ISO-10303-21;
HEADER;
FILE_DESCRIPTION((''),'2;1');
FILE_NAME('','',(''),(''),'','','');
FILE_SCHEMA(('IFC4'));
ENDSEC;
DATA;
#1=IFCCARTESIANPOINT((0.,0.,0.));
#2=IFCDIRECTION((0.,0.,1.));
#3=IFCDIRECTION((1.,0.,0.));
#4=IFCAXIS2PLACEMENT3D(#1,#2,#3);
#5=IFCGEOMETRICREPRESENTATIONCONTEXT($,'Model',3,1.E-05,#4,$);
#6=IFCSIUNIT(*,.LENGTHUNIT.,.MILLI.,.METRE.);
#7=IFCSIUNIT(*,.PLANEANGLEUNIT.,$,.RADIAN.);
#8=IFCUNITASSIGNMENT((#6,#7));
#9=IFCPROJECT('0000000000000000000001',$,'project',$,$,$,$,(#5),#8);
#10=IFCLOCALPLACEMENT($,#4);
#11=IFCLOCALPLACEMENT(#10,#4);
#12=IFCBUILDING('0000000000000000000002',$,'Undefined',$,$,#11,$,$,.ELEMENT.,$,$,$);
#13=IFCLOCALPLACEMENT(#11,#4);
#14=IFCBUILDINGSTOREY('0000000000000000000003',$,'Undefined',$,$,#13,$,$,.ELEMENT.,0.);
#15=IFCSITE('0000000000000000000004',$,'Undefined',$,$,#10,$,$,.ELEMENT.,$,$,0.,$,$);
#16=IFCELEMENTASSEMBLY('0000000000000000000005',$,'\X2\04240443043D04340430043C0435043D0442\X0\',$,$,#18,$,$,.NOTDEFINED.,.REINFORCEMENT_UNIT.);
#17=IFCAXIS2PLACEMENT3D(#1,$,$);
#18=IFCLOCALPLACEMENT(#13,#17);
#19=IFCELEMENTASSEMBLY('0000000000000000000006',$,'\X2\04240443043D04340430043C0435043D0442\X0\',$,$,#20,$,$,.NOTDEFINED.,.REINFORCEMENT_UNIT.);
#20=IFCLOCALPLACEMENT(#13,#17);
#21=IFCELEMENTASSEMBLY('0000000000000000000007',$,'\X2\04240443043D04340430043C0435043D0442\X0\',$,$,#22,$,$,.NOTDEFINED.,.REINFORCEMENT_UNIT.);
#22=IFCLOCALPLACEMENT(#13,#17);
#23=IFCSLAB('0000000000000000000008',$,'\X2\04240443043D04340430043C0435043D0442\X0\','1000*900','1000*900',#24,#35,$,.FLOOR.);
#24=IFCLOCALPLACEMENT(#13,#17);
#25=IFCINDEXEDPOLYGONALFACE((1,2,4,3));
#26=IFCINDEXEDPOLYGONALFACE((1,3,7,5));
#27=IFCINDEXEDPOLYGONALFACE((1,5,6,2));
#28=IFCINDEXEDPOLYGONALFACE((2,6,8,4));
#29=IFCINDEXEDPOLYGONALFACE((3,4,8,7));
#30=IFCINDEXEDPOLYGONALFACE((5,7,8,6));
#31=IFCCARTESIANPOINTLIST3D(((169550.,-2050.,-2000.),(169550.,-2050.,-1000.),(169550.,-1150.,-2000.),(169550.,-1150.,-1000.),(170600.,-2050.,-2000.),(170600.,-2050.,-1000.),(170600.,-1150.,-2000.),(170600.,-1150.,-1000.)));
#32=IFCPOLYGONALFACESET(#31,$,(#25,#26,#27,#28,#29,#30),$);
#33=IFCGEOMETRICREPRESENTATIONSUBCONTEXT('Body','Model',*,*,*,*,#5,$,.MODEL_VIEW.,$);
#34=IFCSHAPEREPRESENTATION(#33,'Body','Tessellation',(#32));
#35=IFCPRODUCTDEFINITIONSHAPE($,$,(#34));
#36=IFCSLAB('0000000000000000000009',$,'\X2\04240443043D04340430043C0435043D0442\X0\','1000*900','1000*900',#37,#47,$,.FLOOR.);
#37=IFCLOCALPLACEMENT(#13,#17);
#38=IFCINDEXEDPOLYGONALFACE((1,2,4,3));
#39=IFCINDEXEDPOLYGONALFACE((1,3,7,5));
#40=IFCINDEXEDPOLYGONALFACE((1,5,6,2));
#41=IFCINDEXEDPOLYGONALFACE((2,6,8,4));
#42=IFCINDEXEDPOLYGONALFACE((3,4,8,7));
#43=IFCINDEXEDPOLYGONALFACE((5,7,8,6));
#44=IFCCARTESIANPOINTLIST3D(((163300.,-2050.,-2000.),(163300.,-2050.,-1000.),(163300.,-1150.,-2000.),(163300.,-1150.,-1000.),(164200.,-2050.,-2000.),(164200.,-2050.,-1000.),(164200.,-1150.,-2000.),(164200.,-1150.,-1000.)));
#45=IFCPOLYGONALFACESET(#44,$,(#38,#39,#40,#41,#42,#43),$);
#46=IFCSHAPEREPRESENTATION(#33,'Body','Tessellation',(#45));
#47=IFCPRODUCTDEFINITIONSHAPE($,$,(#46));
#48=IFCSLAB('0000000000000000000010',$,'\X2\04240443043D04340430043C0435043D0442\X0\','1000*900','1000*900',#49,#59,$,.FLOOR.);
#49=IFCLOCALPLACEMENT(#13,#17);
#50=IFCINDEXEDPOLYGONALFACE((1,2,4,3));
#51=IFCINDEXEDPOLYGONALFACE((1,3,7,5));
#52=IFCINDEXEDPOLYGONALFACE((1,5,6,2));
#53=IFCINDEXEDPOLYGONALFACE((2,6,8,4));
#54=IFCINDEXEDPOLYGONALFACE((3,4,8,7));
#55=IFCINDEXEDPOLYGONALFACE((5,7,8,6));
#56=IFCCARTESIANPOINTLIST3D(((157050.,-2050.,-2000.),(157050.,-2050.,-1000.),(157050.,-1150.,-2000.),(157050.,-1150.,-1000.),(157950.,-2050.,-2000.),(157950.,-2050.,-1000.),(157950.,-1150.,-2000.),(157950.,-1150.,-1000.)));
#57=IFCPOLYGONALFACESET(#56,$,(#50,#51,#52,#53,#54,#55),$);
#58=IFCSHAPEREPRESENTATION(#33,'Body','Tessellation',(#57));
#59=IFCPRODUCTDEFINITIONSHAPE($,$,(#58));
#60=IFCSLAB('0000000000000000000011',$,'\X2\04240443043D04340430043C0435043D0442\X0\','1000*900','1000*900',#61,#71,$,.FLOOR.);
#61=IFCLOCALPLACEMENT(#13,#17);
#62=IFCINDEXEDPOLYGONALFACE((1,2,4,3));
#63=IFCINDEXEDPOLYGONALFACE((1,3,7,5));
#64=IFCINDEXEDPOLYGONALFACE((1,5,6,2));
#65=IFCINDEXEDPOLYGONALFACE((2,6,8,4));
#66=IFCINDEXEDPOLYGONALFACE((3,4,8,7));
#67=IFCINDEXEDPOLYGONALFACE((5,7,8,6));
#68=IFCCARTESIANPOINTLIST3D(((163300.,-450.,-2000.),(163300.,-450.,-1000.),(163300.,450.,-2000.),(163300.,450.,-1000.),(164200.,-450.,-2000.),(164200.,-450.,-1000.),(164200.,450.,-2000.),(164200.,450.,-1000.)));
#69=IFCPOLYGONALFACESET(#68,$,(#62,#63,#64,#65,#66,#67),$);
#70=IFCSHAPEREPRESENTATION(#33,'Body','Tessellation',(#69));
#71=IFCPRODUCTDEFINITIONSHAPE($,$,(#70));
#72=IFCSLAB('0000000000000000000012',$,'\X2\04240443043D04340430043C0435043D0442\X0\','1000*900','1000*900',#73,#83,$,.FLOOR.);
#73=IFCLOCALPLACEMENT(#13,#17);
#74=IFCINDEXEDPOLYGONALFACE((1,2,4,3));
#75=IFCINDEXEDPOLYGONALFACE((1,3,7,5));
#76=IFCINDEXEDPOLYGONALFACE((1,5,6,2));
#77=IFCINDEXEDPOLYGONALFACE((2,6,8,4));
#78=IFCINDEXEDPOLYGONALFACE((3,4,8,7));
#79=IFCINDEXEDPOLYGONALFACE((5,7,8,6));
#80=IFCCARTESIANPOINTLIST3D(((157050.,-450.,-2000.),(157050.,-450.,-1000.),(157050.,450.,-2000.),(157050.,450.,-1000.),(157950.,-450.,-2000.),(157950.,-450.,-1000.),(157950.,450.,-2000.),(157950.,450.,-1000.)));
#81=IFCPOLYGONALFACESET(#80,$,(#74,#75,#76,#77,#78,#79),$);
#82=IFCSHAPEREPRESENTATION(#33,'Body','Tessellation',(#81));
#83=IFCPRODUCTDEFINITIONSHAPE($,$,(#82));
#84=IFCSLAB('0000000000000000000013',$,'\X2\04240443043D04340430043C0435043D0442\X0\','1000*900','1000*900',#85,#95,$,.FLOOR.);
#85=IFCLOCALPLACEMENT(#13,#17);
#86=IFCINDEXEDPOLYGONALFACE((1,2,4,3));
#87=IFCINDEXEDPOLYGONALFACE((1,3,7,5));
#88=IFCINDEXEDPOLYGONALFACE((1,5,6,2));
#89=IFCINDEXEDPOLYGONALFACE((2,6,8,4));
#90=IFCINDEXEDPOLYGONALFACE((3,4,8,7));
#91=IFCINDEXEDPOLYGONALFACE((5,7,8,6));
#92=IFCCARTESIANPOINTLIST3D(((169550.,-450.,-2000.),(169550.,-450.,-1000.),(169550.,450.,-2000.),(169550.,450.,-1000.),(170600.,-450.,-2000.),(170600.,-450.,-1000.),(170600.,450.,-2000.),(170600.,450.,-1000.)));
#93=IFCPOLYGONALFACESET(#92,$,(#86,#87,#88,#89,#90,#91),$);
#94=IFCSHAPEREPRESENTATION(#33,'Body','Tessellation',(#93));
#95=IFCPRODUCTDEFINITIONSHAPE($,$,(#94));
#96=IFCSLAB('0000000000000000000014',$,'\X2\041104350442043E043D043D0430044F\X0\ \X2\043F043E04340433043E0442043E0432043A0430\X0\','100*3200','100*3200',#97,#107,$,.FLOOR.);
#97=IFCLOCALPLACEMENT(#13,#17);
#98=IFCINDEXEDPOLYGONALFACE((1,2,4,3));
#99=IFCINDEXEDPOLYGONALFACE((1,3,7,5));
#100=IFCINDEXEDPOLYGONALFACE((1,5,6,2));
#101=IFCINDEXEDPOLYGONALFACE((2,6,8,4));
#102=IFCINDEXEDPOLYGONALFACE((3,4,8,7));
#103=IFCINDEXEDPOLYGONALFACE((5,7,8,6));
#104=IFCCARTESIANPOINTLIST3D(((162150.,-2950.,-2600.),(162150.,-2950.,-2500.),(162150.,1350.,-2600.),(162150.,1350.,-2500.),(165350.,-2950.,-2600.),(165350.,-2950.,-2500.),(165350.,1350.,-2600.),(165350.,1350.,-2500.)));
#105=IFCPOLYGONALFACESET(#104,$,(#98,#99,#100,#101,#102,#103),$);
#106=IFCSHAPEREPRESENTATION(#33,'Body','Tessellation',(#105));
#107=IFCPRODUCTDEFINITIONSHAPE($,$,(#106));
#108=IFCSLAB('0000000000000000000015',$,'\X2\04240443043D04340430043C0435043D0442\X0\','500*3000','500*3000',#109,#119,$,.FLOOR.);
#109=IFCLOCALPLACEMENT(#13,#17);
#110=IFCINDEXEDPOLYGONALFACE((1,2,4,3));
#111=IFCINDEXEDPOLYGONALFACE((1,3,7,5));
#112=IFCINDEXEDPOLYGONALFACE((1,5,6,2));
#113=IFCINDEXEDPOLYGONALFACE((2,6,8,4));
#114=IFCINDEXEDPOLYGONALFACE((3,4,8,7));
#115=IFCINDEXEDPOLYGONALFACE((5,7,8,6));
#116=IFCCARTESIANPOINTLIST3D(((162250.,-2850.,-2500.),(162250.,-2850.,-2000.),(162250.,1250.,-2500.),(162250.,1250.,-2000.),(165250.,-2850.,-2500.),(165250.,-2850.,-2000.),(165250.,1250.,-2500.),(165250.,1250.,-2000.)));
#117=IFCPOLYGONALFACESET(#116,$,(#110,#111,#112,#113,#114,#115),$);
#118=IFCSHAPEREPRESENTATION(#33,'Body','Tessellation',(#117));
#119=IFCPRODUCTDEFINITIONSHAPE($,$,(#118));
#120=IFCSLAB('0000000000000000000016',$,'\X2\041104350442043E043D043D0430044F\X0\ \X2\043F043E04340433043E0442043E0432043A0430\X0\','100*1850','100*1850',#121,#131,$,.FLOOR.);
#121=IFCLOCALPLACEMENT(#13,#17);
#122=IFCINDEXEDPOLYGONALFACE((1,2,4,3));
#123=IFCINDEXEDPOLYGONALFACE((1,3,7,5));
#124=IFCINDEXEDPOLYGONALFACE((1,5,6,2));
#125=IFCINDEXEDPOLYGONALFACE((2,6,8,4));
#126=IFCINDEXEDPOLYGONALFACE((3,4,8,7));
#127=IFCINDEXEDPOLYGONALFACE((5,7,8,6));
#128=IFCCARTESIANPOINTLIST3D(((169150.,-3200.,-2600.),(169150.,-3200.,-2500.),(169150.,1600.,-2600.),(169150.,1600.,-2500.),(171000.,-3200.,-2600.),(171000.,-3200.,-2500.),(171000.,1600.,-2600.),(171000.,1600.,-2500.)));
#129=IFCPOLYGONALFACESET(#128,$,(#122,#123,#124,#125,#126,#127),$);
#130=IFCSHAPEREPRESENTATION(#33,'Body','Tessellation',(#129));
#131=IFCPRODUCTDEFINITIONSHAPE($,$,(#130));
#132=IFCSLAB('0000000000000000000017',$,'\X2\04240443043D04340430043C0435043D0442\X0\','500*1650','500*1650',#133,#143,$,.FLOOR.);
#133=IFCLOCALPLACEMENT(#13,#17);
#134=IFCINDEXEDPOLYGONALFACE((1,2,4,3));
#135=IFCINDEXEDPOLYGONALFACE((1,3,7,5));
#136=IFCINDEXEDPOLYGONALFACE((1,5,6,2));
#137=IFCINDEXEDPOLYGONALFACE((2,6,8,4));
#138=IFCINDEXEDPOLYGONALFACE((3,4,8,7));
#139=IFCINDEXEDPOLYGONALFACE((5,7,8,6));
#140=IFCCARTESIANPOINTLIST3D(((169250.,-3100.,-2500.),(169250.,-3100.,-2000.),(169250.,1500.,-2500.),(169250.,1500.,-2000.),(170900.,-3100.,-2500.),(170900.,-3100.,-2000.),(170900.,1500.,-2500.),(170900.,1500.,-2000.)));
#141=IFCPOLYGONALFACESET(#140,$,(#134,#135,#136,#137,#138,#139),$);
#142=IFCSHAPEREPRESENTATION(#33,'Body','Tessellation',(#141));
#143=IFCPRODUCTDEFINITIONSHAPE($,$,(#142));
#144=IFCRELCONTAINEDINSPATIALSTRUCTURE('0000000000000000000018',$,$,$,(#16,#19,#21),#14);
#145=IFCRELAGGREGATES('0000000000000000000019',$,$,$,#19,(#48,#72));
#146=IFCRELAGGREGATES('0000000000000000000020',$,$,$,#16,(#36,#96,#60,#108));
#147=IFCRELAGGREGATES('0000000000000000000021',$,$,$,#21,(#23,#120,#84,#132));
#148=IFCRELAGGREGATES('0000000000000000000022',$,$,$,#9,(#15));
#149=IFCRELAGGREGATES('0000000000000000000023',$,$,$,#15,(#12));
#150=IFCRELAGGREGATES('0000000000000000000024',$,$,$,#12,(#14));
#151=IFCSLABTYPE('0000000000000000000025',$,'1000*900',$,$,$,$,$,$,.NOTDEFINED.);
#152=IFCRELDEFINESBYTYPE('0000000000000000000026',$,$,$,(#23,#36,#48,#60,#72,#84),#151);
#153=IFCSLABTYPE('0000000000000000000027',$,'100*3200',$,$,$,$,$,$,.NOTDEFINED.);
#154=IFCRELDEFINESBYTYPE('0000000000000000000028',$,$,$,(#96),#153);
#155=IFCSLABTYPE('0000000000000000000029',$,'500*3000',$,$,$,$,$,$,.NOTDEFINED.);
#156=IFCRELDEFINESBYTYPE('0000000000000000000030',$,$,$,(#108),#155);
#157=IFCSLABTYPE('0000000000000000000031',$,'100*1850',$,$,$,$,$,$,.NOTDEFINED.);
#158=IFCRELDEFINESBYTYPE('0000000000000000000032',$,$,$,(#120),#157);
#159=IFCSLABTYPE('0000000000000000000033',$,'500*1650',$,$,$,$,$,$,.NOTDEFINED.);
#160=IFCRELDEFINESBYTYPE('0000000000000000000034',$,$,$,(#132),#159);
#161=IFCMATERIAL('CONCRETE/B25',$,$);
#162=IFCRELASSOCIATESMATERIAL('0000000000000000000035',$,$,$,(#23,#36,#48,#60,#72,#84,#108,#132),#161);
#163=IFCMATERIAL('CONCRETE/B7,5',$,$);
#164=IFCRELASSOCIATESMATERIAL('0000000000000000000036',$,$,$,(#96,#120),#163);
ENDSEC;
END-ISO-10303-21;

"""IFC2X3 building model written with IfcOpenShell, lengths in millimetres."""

from ifc_helpers import new_model, si_unit, frame, origin_with_axes, place, context, subcontext, project, spatial, polyline, outline, extrude, material, type_object, element, aggregate, save


model = new_model("IFC2X3")

# Units and contexts
model_context = context("Model", 3, precision=1e-05, world=origin_with_axes())
body_context = subcontext(model_context, "Body", "Model", "MODEL_VIEW")
ifc_project = project(units=[si_unit("LENGTHUNIT", "METRE", prefix="MILLI"), si_unit("PLANEANGLEUNIT", "RADIAN")], contexts=[model_context])

# Site, building, storey
site_placement = place(None, origin_with_axes())
site = spatial("IfcSite", under=ifc_project, at=site_placement, Name="Undefined", CompositionType="ELEMENT", RefElevation=0.0)
building_placement = place(site_placement, origin_with_axes())
building = spatial("IfcBuilding", under=site, at=building_placement, Name="Undefined", CompositionType="ELEMENT")
storey_placement = place(building_placement, origin_with_axes())
storey = spatial("IfcBuildingStorey", under=building, at=storey_placement, Name="Undefined", CompositionType="ELEMENT", Elevation=0.0)

# Element assemblies
assembly_1_placement = place(storey_placement, origin_with_axes())
assembly_1 = element("IfcElementAssembly", 1, at=assembly_1_placement, inside=storey, Name="Фундамент", AssemblyPlace="NOTDEFINED", PredefinedType="REINFORCEMENT_UNIT")
ifc_material_1 = material(Name="CONCRETE/B25")
assembly_2_placement = place(storey_placement, origin_with_axes())
assembly_2 = element("IfcElementAssembly", 2, at=assembly_2_placement, inside=storey, Name="Фундамент", AssemblyPlace="NOTDEFINED", PredefinedType="REINFORCEMENT_UNIT")

# Element assembly
assembly_3_placement = place(storey_placement, origin_with_axes())
assembly_3 = element("IfcElementAssembly", 3, at=assembly_3_placement, inside=storey, Name="Фундамент", AssemblyPlace="NOTDEFINED", PredefinedType="REINFORCEMENT_UNIT")

# Shared definitions
ifc_material_2 = material(Name="CONCRETE/B7,5")

# Slabs
slab_type_1 = type_object("IfcSlabType", Name="1000*900", PredefinedType="NOTDEFINED")
slab_1_placement = place(assembly_3_placement, frame((169550.0, -1150.0, -1500.0), z_axis=(0.0, 0.0, 1.0), x_axis=(0.0, -1.0, 0.0)))
slab_1 = element("IfcSlab", 4, at=slab_1_placement, type_object=slab_type_1, material=ifc_material_1, Name="Фундамент", Description="1000*900", ObjectType="1000*900", PredefinedType="FLOOR", context=body_context, shape_type="SweptSolid", body=[
    extrude(outline(polyline([(0.0, 0.0), (900.0, 0.0), (900.0, 1050.0), (0.0, 1050.0), (0.0, 0.0)])), frame((0.0, 0.0, -500.0), z_axis=(0.0, 0.0, 1.0), x_axis=(1.0, 0.0, 0.0)), (0.0, 0.0, 1.0), 1000.0),
])
slab_2_placement = place(assembly_1_placement, frame((163300.0, -1150.0, -1500.0), z_axis=(0.0, 0.0, 1.0), x_axis=(0.0, -1.0, 0.0)))
slab_2 = element("IfcSlab", 5, at=slab_2_placement, type_object=slab_type_1, material=ifc_material_1, Name="Фундамент", Description="1000*900", ObjectType="1000*900", PredefinedType="FLOOR", context=body_context, shape_type="SweptSolid", body=[
    extrude(outline(polyline([(0.0, 0.0), (900.0, 0.0), (900.0, 900.0), (0.0, 900.0), (0.0, 0.0)])), frame((0.0, 0.0, -500.0), z_axis=(0.0, 0.0, 1.0), x_axis=(1.0, 0.0, 0.0)), (0.0, 0.0, 1.0), 1000.0),
])
slab_3_placement = place(assembly_2_placement, frame((157050.0, -1150.0, -1500.0), z_axis=(0.0, 0.0, 1.0), x_axis=(0.0, -1.0, 0.0)))
slab_3 = element("IfcSlab", 6, at=slab_3_placement, type_object=slab_type_1, material=ifc_material_1, Name="Фундамент", Description="1000*900", ObjectType="1000*900", PredefinedType="FLOOR", context=body_context, shape_type="SweptSolid", body=[
    extrude(outline(polyline([(0.0, 0.0), (900.0, 0.0), (900.0, 900.0), (0.0, 900.0), (0.0, 0.0)])), frame((0.0, 0.0, -500.0), z_axis=(0.0, 0.0, 1.0), x_axis=(1.0, 0.0, 0.0)), (0.0, 0.0, 1.0), 1000.0),
])
slab_4_placement = place(assembly_1_placement, frame((163300.0, 450.0, -1500.0), z_axis=(0.0, 0.0, 1.0), x_axis=(0.0, -1.0, 0.0)))
slab_4 = element("IfcSlab", 7, at=slab_4_placement, type_object=slab_type_1, material=ifc_material_1, Name="Фундамент", Description="1000*900", ObjectType="1000*900", PredefinedType="FLOOR", context=body_context, shape_type="SweptSolid", body=[
    extrude(outline(polyline([(0.0, 0.0), (900.0, 0.0), (900.0, 900.0), (0.0, 900.0), (0.0, 0.0)])), frame((0.0, 0.0, -500.0), z_axis=(0.0, 0.0, 1.0), x_axis=(1.0, 0.0, 0.0)), (0.0, 0.0, 1.0), 1000.0),
])
slab_5_placement = place(assembly_2_placement, frame((157050.0, 450.0, -1500.0), z_axis=(0.0, 0.0, 1.0), x_axis=(0.0, -1.0, 0.0)))
slab_5 = element("IfcSlab", 8, at=slab_5_placement, type_object=slab_type_1, material=ifc_material_1, Name="Фундамент", Description="1000*900", ObjectType="1000*900", PredefinedType="FLOOR", context=body_context, shape_type="SweptSolid", body=[
    extrude(outline(polyline([(0.0, 0.0), (900.0, 0.0), (900.0, 900.0), (0.0, 900.0), (0.0, 0.0)])), frame((0.0, 0.0, -500.0), z_axis=(0.0, 0.0, 1.0), x_axis=(1.0, 0.0, 0.0)), (0.0, 0.0, 1.0), 1000.0),
])
aggregate(assembly_2, [slab_3, slab_5])
slab_6_placement = place(assembly_3_placement, frame((169550.0, 450.0, -1500.0), z_axis=(0.0, 0.0, 1.0), x_axis=(0.0, -1.0, 0.0)))
slab_6 = element("IfcSlab", 9, at=slab_6_placement, type_object=slab_type_1, material=ifc_material_1, Name="Фундамент", Description="1000*900", ObjectType="1000*900", PredefinedType="FLOOR", context=body_context, shape_type="SweptSolid", body=[
    extrude(outline(polyline([(0.0, 0.0), (900.0, 0.0), (900.0, 1050.0), (0.0, 1050.0), (0.0, 0.0)])), frame((0.0, 0.0, -500.0), z_axis=(0.0, 0.0, 1.0), x_axis=(1.0, 0.0, 0.0)), (0.0, 0.0, 1.0), 1000.0),
])
slab_type_2 = type_object("IfcSlabType", Name="100*3200", PredefinedType="NOTDEFINED")
slab_7_placement = place(assembly_1_placement, frame((162150.0, 1350.0, -2550.0), z_axis=(0.0, 0.0, 1.0), x_axis=(0.0, -1.0, 0.0)))
slab_7 = element("IfcSlab", 10, at=slab_7_placement, type_object=slab_type_2, material=ifc_material_2, Name="Бетонная подготовка", Description="100*3200", ObjectType="100*3200", PredefinedType="FLOOR", context=body_context, shape_type="SweptSolid", body=[
    extrude(outline(polyline([(0.0, 0.0), (4300.0, 0.0), (4300.0, 3200.0), (0.0, 3200.0), (0.0, 0.0)])), frame((0.0, 0.0, -50.0), z_axis=(0.0, 0.0, 1.0), x_axis=(1.0, 0.0, 0.0)), (0.0, 0.0, 1.0), 100.0),
])
slab_type_3 = type_object("IfcSlabType", Name="500*3000", PredefinedType="NOTDEFINED")
slab_8_placement = place(assembly_1_placement, frame((162250.0, 1250.0, -2250.0), z_axis=(0.0, 0.0, 1.0), x_axis=(0.0, -1.0, 0.0)))
slab_8 = element("IfcSlab", 11, at=slab_8_placement, type_object=slab_type_3, material=ifc_material_1, Name="Фундамент", Description="500*3000", ObjectType="500*3000", PredefinedType="FLOOR", context=body_context, shape_type="SweptSolid", body=[
    extrude(outline(polyline([(0.0, 0.0), (4100.0, 0.0), (4100.0, 3000.0), (0.0, 3000.0), (0.0, 0.0)])), frame((0.0, 0.0, -250.0), z_axis=(0.0, 0.0, 1.0), x_axis=(1.0, 0.0, 0.0)), (0.0, 0.0, 1.0), 500.0),
])
aggregate(assembly_1, [slab_2, slab_7, slab_4, slab_8])
slab_type_4 = type_object("IfcSlabType", Name="100*1850", PredefinedType="NOTDEFINED")
slab_9_placement = place(assembly_3_placement, frame((169150.0, 1600.0, -2550.0), z_axis=(0.0, 0.0, 1.0), x_axis=(0.0, -1.0, 0.0)))
slab_9 = element("IfcSlab", 12, at=slab_9_placement, type_object=slab_type_4, material=ifc_material_2, Name="Бетонная подготовка", Description="100*1850", ObjectType="100*1850", PredefinedType="FLOOR", context=body_context, shape_type="SweptSolid", body=[
    extrude(outline(polyline([(0.0, 0.0), (4800.0, 0.0), (4800.0, 1850.0), (0.0, 1850.0), (0.0, 0.0)])), frame((0.0, 0.0, -50.0), z_axis=(0.0, 0.0, 1.0), x_axis=(1.0, 0.0, 0.0)), (0.0, 0.0, 1.0), 100.0),
])
slab_type_5 = type_object("IfcSlabType", Name="500*1650", PredefinedType="NOTDEFINED")
slab_10_placement = place(assembly_3_placement, frame((169250.0, 1500.0, -2250.0), z_axis=(0.0, 0.0, 1.0), x_axis=(0.0, -1.0, 0.0)))
slab_10 = element("IfcSlab", 13, at=slab_10_placement, type_object=slab_type_5, material=ifc_material_1, Name="Фундамент", Description="500*1650", ObjectType="500*1650", PredefinedType="FLOOR", context=body_context, shape_type="SweptSolid", body=[
    extrude(outline(polyline([(0.0, 0.0), (4600.0, 0.0), (4600.0, 1650.0), (0.0, 1650.0), (0.0, 0.0)])), frame((0.0, 0.0, -250.0), z_axis=(0.0, 0.0, 1.0), x_axis=(1.0, 0.0, 0.0)), (0.0, 0.0, 1.0), 500.0),
])
aggregate(assembly_3, [slab_1, slab_9, slab_6, slab_10])

save(model, "model.ifc")
